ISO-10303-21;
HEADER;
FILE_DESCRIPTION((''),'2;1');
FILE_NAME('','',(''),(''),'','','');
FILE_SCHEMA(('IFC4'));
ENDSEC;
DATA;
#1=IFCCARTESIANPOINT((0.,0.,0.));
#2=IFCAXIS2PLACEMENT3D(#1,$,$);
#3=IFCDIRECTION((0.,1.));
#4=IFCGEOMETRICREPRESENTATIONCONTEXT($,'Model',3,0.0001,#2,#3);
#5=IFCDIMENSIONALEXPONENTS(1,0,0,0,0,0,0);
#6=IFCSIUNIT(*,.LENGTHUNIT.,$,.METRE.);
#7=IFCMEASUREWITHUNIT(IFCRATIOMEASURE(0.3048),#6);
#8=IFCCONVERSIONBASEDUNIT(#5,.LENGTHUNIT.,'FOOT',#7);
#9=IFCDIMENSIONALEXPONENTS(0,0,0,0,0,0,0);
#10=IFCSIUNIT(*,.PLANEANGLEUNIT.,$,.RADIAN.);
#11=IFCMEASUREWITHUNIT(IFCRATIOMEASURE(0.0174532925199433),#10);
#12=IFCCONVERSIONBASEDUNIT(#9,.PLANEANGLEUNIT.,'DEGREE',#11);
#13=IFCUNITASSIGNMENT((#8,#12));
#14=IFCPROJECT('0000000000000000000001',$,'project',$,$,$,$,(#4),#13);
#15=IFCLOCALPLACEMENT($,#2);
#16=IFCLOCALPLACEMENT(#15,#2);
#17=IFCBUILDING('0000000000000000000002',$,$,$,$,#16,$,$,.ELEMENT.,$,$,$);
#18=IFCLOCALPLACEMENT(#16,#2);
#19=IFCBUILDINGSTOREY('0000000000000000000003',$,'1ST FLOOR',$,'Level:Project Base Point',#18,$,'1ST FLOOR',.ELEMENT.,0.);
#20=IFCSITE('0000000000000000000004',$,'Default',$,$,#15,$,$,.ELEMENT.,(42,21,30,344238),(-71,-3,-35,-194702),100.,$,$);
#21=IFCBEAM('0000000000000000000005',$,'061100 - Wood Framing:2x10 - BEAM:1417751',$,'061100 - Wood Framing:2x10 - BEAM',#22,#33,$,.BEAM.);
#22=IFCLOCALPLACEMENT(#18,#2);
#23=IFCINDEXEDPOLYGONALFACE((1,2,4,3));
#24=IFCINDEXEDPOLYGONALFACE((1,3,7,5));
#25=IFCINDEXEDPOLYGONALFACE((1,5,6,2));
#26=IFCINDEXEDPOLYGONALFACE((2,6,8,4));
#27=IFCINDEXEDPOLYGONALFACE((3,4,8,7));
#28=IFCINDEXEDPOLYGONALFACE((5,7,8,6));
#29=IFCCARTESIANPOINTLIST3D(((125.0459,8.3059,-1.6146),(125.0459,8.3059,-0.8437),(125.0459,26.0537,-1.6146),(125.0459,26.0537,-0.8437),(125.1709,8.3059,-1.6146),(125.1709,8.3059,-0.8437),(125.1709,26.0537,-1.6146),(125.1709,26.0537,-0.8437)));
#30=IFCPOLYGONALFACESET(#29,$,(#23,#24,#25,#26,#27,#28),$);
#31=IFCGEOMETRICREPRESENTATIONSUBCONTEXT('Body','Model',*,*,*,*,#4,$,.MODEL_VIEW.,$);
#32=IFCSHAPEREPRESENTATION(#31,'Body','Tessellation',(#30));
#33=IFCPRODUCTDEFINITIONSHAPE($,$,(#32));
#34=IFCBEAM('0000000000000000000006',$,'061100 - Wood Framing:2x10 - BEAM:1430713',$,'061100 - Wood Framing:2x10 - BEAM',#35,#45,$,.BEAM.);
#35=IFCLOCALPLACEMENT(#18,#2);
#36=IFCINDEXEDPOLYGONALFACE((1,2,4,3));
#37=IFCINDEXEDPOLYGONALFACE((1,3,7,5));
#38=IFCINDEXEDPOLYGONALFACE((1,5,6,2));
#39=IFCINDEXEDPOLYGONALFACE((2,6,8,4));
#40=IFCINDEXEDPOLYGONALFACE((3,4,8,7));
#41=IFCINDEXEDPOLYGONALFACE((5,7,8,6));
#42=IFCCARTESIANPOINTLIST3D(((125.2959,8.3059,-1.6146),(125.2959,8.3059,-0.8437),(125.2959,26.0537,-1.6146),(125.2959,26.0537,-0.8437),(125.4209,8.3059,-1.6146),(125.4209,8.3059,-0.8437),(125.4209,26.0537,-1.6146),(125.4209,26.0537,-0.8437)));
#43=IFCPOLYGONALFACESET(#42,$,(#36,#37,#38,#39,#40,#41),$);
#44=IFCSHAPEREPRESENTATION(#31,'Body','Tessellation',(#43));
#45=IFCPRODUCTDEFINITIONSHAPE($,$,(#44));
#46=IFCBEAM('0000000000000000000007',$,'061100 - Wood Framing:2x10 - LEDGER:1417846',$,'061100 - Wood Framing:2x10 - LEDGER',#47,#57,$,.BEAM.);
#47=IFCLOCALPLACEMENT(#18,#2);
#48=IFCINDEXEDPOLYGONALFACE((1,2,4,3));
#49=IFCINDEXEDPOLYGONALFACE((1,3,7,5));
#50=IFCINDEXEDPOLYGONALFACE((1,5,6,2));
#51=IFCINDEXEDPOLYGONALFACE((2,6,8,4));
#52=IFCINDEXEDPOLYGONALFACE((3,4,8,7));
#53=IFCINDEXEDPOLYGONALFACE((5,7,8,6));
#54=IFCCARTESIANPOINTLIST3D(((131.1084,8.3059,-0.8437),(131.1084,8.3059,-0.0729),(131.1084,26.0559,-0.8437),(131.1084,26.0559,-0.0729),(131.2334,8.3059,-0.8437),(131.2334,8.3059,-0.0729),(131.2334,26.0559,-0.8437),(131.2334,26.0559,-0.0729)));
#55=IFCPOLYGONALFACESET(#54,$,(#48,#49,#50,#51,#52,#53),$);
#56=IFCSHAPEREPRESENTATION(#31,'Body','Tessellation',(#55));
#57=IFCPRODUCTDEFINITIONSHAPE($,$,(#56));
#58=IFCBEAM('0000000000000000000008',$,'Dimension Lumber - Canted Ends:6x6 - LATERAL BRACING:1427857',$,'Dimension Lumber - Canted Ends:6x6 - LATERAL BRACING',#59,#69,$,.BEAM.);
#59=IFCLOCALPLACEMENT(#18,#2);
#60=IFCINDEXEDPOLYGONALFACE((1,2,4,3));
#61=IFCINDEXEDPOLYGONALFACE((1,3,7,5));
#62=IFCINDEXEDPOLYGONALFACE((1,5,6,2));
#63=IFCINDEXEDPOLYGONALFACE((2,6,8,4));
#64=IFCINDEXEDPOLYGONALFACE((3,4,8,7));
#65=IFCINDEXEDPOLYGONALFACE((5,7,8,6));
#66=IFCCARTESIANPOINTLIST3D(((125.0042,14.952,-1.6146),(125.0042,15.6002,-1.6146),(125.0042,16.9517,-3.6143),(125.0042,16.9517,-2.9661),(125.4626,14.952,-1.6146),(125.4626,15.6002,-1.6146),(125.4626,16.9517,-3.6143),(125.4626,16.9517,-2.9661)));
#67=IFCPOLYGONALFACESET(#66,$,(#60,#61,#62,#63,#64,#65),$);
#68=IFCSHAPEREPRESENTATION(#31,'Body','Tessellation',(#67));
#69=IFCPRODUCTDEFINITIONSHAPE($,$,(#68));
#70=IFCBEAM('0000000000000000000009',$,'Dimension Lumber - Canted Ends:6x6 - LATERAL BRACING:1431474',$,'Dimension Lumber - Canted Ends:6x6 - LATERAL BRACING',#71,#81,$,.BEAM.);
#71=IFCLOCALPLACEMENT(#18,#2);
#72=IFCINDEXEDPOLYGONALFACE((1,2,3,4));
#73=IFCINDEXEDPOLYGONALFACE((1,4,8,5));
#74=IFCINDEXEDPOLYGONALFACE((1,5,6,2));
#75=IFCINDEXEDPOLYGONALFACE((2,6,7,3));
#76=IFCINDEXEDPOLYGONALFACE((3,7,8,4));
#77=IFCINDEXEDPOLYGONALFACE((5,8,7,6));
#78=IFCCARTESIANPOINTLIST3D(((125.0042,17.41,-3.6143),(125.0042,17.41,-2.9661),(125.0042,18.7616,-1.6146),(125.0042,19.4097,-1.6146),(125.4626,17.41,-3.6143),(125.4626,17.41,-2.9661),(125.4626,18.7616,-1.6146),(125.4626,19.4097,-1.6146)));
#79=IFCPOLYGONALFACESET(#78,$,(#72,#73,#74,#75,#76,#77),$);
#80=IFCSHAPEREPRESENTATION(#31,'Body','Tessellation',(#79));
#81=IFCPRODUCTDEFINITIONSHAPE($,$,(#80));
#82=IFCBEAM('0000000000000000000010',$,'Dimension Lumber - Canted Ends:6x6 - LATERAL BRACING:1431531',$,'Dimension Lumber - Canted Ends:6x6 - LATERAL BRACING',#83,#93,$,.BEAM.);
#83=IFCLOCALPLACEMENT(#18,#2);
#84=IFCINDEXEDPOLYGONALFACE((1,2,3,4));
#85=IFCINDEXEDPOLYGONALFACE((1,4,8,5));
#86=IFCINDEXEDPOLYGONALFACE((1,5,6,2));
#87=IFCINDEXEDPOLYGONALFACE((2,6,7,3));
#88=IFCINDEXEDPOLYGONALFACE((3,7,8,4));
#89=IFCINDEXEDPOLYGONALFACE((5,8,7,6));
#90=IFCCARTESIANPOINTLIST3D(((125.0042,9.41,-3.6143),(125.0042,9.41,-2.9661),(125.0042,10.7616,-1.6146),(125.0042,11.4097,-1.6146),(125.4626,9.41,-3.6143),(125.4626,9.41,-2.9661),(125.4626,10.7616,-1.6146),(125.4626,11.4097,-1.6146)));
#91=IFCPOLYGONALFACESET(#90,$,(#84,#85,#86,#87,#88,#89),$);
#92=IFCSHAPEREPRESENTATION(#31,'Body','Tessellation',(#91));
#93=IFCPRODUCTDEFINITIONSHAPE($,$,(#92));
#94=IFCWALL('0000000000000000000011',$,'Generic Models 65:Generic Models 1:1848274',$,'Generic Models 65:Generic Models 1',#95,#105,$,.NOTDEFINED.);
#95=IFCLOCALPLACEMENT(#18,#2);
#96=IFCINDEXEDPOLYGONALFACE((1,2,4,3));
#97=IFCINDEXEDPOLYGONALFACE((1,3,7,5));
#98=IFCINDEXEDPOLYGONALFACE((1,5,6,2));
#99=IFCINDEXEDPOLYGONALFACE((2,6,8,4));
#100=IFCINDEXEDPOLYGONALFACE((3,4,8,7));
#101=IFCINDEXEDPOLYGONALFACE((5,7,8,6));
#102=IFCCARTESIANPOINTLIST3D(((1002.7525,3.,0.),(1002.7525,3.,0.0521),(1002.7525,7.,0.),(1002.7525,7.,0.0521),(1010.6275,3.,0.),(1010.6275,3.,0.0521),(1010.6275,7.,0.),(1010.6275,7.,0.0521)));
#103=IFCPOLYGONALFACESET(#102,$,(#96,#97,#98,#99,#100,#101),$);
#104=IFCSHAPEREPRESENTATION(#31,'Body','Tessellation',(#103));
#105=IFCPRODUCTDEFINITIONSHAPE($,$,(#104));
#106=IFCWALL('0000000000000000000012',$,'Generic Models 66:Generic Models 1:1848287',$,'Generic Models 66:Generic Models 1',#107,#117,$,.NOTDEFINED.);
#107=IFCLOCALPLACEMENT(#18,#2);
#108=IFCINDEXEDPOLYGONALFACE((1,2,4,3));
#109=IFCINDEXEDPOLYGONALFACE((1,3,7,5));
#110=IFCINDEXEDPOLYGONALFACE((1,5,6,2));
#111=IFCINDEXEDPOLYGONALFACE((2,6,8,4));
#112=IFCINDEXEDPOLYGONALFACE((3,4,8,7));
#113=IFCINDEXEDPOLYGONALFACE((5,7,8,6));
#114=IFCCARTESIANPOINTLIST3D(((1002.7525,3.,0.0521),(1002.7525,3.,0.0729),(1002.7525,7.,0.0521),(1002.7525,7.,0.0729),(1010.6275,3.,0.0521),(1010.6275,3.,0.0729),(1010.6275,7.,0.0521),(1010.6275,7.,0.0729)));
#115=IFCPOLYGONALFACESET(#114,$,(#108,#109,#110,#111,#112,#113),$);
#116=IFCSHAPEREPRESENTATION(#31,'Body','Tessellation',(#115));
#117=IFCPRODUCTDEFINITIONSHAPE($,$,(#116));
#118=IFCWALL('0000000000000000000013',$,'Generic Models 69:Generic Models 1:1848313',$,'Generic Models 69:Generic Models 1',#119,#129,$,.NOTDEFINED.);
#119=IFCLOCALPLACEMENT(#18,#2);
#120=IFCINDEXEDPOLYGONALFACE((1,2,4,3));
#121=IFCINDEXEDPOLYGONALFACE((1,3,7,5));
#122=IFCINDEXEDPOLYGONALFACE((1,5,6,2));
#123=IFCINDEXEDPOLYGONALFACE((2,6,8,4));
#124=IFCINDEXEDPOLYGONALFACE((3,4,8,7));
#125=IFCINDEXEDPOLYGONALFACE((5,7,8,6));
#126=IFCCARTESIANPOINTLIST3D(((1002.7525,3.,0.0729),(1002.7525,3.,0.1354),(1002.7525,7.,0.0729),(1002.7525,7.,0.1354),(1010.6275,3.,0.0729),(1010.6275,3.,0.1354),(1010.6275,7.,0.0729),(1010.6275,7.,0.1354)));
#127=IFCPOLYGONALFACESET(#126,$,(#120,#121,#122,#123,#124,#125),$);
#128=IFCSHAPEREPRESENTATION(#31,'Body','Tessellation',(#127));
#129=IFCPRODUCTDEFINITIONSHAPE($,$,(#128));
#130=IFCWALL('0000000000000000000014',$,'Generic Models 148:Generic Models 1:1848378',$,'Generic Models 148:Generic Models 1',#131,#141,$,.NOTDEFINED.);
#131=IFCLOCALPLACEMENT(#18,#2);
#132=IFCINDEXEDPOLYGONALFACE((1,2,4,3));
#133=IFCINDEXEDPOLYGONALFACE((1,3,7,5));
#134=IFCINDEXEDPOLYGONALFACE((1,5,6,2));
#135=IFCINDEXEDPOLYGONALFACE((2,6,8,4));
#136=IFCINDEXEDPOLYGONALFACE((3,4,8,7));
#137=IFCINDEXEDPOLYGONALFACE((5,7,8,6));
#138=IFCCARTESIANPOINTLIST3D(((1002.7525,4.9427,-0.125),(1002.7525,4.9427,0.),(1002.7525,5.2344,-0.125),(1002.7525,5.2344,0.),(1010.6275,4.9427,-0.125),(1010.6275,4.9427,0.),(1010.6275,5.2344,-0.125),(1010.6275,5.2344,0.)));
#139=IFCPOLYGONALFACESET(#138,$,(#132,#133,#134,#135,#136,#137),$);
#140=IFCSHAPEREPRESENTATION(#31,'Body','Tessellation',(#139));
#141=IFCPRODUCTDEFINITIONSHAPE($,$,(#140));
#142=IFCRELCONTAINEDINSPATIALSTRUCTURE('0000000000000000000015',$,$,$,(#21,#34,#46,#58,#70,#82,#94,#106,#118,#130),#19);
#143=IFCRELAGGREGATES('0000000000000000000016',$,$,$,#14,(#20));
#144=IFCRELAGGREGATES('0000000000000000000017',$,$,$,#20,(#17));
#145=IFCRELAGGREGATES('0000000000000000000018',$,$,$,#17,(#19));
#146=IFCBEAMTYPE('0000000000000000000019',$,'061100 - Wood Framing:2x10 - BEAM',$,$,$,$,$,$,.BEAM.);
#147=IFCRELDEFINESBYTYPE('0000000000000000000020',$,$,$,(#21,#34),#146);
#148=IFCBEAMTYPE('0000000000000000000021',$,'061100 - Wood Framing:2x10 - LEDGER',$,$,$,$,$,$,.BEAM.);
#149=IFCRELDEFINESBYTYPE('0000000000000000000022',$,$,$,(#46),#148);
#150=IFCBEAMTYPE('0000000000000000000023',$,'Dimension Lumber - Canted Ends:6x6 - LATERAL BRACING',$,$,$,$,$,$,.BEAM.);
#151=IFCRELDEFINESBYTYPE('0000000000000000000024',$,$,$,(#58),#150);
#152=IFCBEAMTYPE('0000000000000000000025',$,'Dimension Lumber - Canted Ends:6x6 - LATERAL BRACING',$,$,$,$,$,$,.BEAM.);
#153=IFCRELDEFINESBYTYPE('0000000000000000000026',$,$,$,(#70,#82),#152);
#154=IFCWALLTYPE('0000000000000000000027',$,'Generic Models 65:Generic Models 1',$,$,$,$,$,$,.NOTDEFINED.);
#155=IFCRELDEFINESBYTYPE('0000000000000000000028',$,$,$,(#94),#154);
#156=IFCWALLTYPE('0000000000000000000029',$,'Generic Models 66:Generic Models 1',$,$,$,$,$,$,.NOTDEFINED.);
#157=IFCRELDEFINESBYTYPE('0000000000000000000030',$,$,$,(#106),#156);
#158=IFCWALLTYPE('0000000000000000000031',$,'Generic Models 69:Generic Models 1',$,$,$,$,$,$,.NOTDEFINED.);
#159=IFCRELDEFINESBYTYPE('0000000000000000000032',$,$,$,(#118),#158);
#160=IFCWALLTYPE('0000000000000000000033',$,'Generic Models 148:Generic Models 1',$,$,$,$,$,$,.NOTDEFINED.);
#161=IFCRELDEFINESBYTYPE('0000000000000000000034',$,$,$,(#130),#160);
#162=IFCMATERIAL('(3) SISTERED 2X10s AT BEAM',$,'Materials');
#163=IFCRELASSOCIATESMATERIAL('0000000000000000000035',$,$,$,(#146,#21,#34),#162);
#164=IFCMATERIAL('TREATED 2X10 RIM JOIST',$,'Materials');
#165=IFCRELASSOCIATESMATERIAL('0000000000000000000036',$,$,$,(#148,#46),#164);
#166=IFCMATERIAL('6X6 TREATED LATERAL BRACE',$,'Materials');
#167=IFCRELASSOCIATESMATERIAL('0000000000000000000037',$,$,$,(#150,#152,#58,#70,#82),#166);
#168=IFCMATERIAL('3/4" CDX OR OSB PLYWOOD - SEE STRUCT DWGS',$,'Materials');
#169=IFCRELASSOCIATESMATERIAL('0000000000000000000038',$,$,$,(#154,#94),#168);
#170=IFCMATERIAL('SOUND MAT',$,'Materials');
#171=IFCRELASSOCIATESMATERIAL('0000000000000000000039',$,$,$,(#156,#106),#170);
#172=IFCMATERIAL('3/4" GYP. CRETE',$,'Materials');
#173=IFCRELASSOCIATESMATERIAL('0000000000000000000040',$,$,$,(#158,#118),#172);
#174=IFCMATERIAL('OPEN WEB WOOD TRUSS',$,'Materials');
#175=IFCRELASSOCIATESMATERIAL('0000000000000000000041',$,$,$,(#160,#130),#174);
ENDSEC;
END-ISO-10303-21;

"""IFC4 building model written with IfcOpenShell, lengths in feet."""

from ifc_helpers import new_model, entity, si_unit, converted_unit, direction, frame, frame_2d, origin, origin_2d_with_axis, place, context, subcontext, project, spatial, rectangle, extrude, clip, halfspace, source, transform, mapped, material, material_profile, profile_set, profile_usage, type_object, type_shapes, element, save


model = new_model("IFC4")

# Units and contexts
model_context = context("Model", 3, precision=0.0001, world=origin(), true_north=direction((0.0, 1.0)))
body_context = subcontext(model_context, "Body", "Model", "MODEL_VIEW")
ifc_project = project(units=[converted_unit("LENGTHUNIT", "FOOT", entity("IfcRatioMeasure", 0.3048), si_unit("LENGTHUNIT", "METRE"), dimensions=[1, 0, 0, 0, 0, 0, 0]), converted_unit("PLANEANGLEUNIT", "DEGREE", entity("IfcRatioMeasure", 0.0174532925199433), si_unit("PLANEANGLEUNIT", "RADIAN"), dimensions=[0, 0, 0, 0, 0, 0, 0])], contexts=[model_context])

# Site, building, storey
site_placement = place(None, origin())
site = spatial("IfcSite", under=ifc_project, at=site_placement, Name="Default", CompositionType="ELEMENT", RefLatitude=(42, 21, 30, 344238), RefLongitude=(-71, -3, -35, -194702), RefElevation=100.0)
building_placement = place(site_placement, origin())
building = spatial("IfcBuilding", under=site, at=building_placement, CompositionType="ELEMENT")
storey_placement = place(building_placement, origin())
storey = spatial("IfcBuildingStorey", under=building, at=storey_placement, Name="1ST FLOOR", ObjectType="Level:Project Base Point", LongName="1ST FLOOR", CompositionType="ELEMENT", Elevation=0.0)

# Shared definitions
ifc_material_1 = material(Name="TREATED 2X10 RIM JOIST", Category="Materials")

# Beams
ifc_material_2 = material(Name="(3) SISTERED 2X10s AT BEAM", Category="Materials")
ifc_material_profile_1 = material_profile(ifc_material_2, rectangle(XDim=0.7708, YDim=0.125, at=frame_2d((0.0, 0.0), x_axis=(1.0, 0.0))), Name="2x10 - BEAM")
ifc_profile_set_1 = profile_set([ifc_material_profile_1], Name="2x10 - BEAM")
beam_type_1 = type_object("IfcBeamType", Name="061100 - Wood Framing:2x10 - BEAM", PredefinedType="BEAM", material=ifc_profile_set_1)
shared_shape_1 = source(origin(), body_context, "Body", "SweptSolid", [
    extrude(rectangle(XDim=0.7708, YDim=0.125, at=frame_2d((0.0, 0.0), x_axis=(1.0, 0.0))), frame((-8.8427, 0.0, 0.0), z_axis=(1.0, 0.0, 0.0), x_axis=(0.0, 0.0, -1.0)), (0.0, 0.0, 1.0), 17.7478),
])
type_shapes(beam_type_1, [shared_shape_1])
ifc_profile_usage_1 = profile_usage(ifc_profile_set_1, cardinal=8)
beam_1_placement = place(storey_placement, frame((125.1084, 17.1485, -1.2292), z_axis=(0.0, 0.0, 1.0), x_axis=(0.0, 1.0, 0.0)))
element("IfcBeam", 1, at=beam_1_placement, inside=storey, type_object=beam_type_1, material=ifc_profile_usage_1, Name="061100 - Wood Framing:2x10 - BEAM:1417751", ObjectType="061100 - Wood Framing:2x10 - BEAM", PredefinedType="BEAM", context=body_context, shape_type="MappedRepresentation", body=[
    mapped(shared_shape_1, transform((0.0, 0.0, 0.0), scale=1.0)),
])
ifc_profile_usage_2 = profile_usage(ifc_profile_set_1, cardinal=8)
beam_2_placement = place(storey_placement, frame((125.3584, 17.1485, -1.2292), z_axis=(0.0, 0.0, 1.0), x_axis=(0.0, 1.0, 0.0)))
element("IfcBeam", 2, at=beam_2_placement, inside=storey, type_object=beam_type_1, material=ifc_profile_usage_2, Name="061100 - Wood Framing:2x10 - BEAM:1430713", ObjectType="061100 - Wood Framing:2x10 - BEAM", PredefinedType="BEAM", context=body_context, shape_type="MappedRepresentation", body=[
    mapped(shared_shape_1, transform((0.0, 0.0, 0.0), scale=1.0)),
])
ifc_material_profile_2 = material_profile(ifc_material_1, rectangle(XDim=0.7708, YDim=0.125, at=frame_2d((0.0, 0.0), x_axis=(1.0, 0.0))), Name="2x10 - LEDGER")
ifc_profile_set_2 = profile_set([ifc_material_profile_2], Name="2x10 - LEDGER")
ifc_profile_usage_3 = profile_usage(ifc_profile_set_2, cardinal=8)
beam_type_2 = type_object("IfcBeamType", Name="061100 - Wood Framing:2x10 - LEDGER", PredefinedType="BEAM", material=ifc_profile_set_2)
shared_shape_2 = source(origin(), body_context, "Body", "SweptSolid", [
    extrude(rectangle(XDim=0.7708, YDim=0.125, at=frame_2d((0.0, 0.0), x_axis=(1.0, 0.0))), frame((-8.875, 0.0, 0.0), z_axis=(1.0, 0.0, 0.0), x_axis=(0.0, 0.0, -1.0)), (0.0, 0.0, 1.0), 17.75),
])
type_shapes(beam_type_2, [shared_shape_2])
beam_3_placement = place(storey_placement, frame((131.1709, 17.1809, -0.4583), z_axis=(0.0, 0.0, 1.0), x_axis=(0.0, -1.0, 0.0)))
element("IfcBeam", 3, at=beam_3_placement, inside=storey, type_object=beam_type_2, material=ifc_profile_usage_3, Name="061100 - Wood Framing:2x10 - LEDGER:1417846", ObjectType="061100 - Wood Framing:2x10 - LEDGER", PredefinedType="BEAM", context=body_context, shape_type="MappedRepresentation", body=[
    mapped(shared_shape_2, transform((0.0, 0.0, 0.0), scale=1.0)),
])
ifc_material_3 = material(Name="6X6 TREATED LATERAL BRACE", Category="Materials")
ifc_material_profile_3 = material_profile(ifc_material_3, rectangle(XDim=0.4583, YDim=0.4583, at=origin_2d_with_axis()), Name="6x6 - LATERAL BRACING")
ifc_profile_set_3 = profile_set([ifc_material_profile_3], Name="6x6 - LATERAL BRACING")
ifc_profile_usage_4 = profile_usage(ifc_profile_set_3, cardinal=2)
beam_type_3 = type_object("IfcBeamType", Name="Dimension Lumber - Canted Ends:6x6 - LATERAL BRACING", PredefinedType="BEAM", material=ifc_profile_set_3)
shared_shape_3 = source(origin(), body_context, "Body", "Clipping", [
    clip(clip(extrude(rectangle(XDim=0.4583, YDim=0.4583, at=origin_2d_with_axis()), frame((-1.414, 0.0, 0.0), z_axis=(1.0, 0.0, 0.0), x_axis=(0.0, 0.0, -1.0)), (0.0, 0.0, 1.0), 2.828), halfspace(frame((-0.9557, 0.2292, 0.2292), z_axis=(-0.707107, 0.0, 0.707107), x_axis=(0.0, -1.0, 0.0)), False)), halfspace(frame((1.414, 0.2292, -0.2292), z_axis=(0.707107, 0.0, 0.707107), x_axis=(0.0, -1.0, 0.0)), False)),
])
type_shapes(beam_type_3, [shared_shape_3])
beam_4_placement = place(storey_placement, frame((125.2334, 16.1139, -2.4524), z_axis=(0.0, 0.707107, 0.707107), x_axis=(0.0, 0.707107, -0.707107)))
element("IfcBeam", 4, at=beam_4_placement, inside=storey, type_object=beam_type_3, material=ifc_profile_usage_4, Name="Dimension Lumber - Canted Ends:6x6 - LATERAL BRACING:1427857", ObjectType="Dimension Lumber - Canted Ends:6x6 - LATERAL BRACING", PredefinedType="BEAM", context=body_context, shape_type="MappedRepresentation", body=[
    mapped(shared_shape_3, transform((0.0, 0.0, 0.0), scale=1.0)),
])
ifc_profile_usage_5 = profile_usage(ifc_profile_set_3, cardinal=2)
beam_type_4 = type_object("IfcBeamType", Name="Dimension Lumber - Canted Ends:6x6 - LATERAL BRACING", PredefinedType="BEAM", material=ifc_profile_set_3)
shared_shape_4 = source(origin(), body_context, "Body", "Clipping", [
    clip(clip(extrude(rectangle(XDim=0.4583, YDim=0.4583, at=frame_2d((0.0, 0.0), x_axis=(1.0, 0.0))), frame((-1.414, 0.0, 0.0), z_axis=(1.0, 0.0, 0.0), x_axis=(0.0, 0.0, -1.0)), (0.0, 0.0, 1.0), 2.828), halfspace(frame((-0.9557, -0.2292, 0.2292), z_axis=(-0.707107, 0.0, 0.707107), x_axis=(0.0, 1.0, 0.0)), False)), halfspace(frame((1.414, -0.2292, -0.2292), z_axis=(0.707107, 0.0, 0.707107), x_axis=(0.0, 1.0, 0.0)), False)),
])
type_shapes(beam_type_4, [shared_shape_4])
beam_5_placement = place(storey_placement, frame((125.2334, 18.2478, -2.4524), z_axis=(0.0, -0.707107, 0.707107), x_axis=(0.0, -0.707107, -0.707107)))
element("IfcBeam", 5, at=beam_5_placement, inside=storey, type_object=beam_type_4, material=ifc_profile_usage_5, Name="Dimension Lumber - Canted Ends:6x6 - LATERAL BRACING:1431474", ObjectType="Dimension Lumber - Canted Ends:6x6 - LATERAL BRACING", PredefinedType="BEAM", context=body_context, shape_type="MappedRepresentation", body=[
    mapped(shared_shape_4, transform((0.0, 0.0, 0.0), scale=1.0)),
])
ifc_profile_usage_6 = profile_usage(ifc_profile_set_3, cardinal=2)
beam_6_placement = place(storey_placement, frame((125.2334, 10.2478, -2.4524), z_axis=(0.0, -0.707107, 0.707107), x_axis=(0.0, -0.707107, -0.707107)))
element("IfcBeam", 6, at=beam_6_placement, inside=storey, type_object=beam_type_4, material=ifc_profile_usage_6, Name="Dimension Lumber - Canted Ends:6x6 - LATERAL BRACING:1431531", ObjectType="Dimension Lumber - Canted Ends:6x6 - LATERAL BRACING", PredefinedType="BEAM", context=body_context, shape_type="MappedRepresentation", body=[
    mapped(shared_shape_4, transform((0.0, 0.0, 0.0), scale=1.0)),
])

# Walls
ifc_material_4 = material(Name="3/4\" CDX OR OSB PLYWOOD - SEE STRUCT DWGS", Category="Materials")
wall_type_1 = type_object("IfcWallType", Name="Generic Models 65:Generic Models 1", PredefinedType="NOTDEFINED", material=ifc_material_4)
wall_1_placement = place(storey_placement, frame((1002.7525, 3.0, 0.0)))
element("IfcWall", 7, at=wall_1_placement, inside=storey, type_object=wall_type_1, material=ifc_material_4, Name="Generic Models 65:Generic Models 1:1848274", ObjectType="Generic Models 65:Generic Models 1", PredefinedType="NOTDEFINED", context=body_context, shape_type="SweptSolid", body=[
    extrude(rectangle(XDim=4.0, YDim=7.875, at=frame_2d((0.0, 0.0), x_axis=(1.0, 0.0))), frame((3.9375, 2.0, 0.0), z_axis=(0.0, 0.0, 1.0), x_axis=(0.0, 1.0, 0.0)), (0.0, 0.0, 1.0), 0.0521),
])
ifc_material_5 = material(Name="SOUND MAT", Category="Materials")
wall_type_2 = type_object("IfcWallType", Name="Generic Models 66:Generic Models 1", PredefinedType="NOTDEFINED", material=ifc_material_5)
wall_2_placement = place(storey_placement, frame((1002.7525, 3.0, 0.0521)))
element("IfcWall", 8, at=wall_2_placement, inside=storey, type_object=wall_type_2, material=ifc_material_5, Name="Generic Models 66:Generic Models 1:1848287", ObjectType="Generic Models 66:Generic Models 1", PredefinedType="NOTDEFINED", context=body_context, shape_type="SweptSolid", body=[
    extrude(rectangle(XDim=4.0, YDim=7.875, at=frame_2d((0.0, 0.0), x_axis=(1.0, 0.0))), frame((3.9375, 2.0, 0.0), z_axis=(0.0, 0.0, 1.0), x_axis=(0.0, 1.0, 0.0)), (0.0, 0.0, 1.0), 0.0208),
])
ifc_material_6 = material(Name="3/4\" GYP. CRETE", Category="Materials")
wall_type_3 = type_object("IfcWallType", Name="Generic Models 69:Generic Models 1", PredefinedType="NOTDEFINED", material=ifc_material_6)
wall_3_placement = place(storey_placement, frame((1002.7525, 3.0, 0.0729)))
element("IfcWall", 9, at=wall_3_placement, inside=storey, type_object=wall_type_3, material=ifc_material_6, Name="Generic Models 69:Generic Models 1:1848313", ObjectType="Generic Models 69:Generic Models 1", PredefinedType="NOTDEFINED", context=body_context, shape_type="SweptSolid", body=[
    extrude(rectangle(XDim=4.0, YDim=7.875, at=frame_2d((0.0, 0.0), x_axis=(1.0, 0.0))), frame((3.9375, 2.0, 0.0), z_axis=(0.0, 0.0, 1.0), x_axis=(0.0, 1.0, 0.0)), (0.0, 0.0, 1.0), 0.0625),
])
ifc_material_7 = material(Name="OPEN WEB WOOD TRUSS", Category="Materials")
wall_type_4 = type_object("IfcWallType", Name="Generic Models 148:Generic Models 1", PredefinedType="NOTDEFINED", material=ifc_material_7)
wall_4_placement = place(storey_placement, frame((1002.7525, 4.9427, -0.125)))
element("IfcWall", 10, at=wall_4_placement, inside=storey, type_object=wall_type_4, material=ifc_material_7, Name="Generic Models 148:Generic Models 1:1848378", ObjectType="Generic Models 148:Generic Models 1", PredefinedType="NOTDEFINED", context=body_context, shape_type="SweptSolid", body=[
    extrude(rectangle(XDim=0.2917, YDim=7.875, at=origin_2d_with_axis()), frame((3.9375, 0.1458, 0.0), z_axis=(0.0, 0.0, 1.0), x_axis=(0.0, 1.0, 0.0)), (0.0, 0.0, 1.0), 0.125),
])

save(model, "model.ifc")
